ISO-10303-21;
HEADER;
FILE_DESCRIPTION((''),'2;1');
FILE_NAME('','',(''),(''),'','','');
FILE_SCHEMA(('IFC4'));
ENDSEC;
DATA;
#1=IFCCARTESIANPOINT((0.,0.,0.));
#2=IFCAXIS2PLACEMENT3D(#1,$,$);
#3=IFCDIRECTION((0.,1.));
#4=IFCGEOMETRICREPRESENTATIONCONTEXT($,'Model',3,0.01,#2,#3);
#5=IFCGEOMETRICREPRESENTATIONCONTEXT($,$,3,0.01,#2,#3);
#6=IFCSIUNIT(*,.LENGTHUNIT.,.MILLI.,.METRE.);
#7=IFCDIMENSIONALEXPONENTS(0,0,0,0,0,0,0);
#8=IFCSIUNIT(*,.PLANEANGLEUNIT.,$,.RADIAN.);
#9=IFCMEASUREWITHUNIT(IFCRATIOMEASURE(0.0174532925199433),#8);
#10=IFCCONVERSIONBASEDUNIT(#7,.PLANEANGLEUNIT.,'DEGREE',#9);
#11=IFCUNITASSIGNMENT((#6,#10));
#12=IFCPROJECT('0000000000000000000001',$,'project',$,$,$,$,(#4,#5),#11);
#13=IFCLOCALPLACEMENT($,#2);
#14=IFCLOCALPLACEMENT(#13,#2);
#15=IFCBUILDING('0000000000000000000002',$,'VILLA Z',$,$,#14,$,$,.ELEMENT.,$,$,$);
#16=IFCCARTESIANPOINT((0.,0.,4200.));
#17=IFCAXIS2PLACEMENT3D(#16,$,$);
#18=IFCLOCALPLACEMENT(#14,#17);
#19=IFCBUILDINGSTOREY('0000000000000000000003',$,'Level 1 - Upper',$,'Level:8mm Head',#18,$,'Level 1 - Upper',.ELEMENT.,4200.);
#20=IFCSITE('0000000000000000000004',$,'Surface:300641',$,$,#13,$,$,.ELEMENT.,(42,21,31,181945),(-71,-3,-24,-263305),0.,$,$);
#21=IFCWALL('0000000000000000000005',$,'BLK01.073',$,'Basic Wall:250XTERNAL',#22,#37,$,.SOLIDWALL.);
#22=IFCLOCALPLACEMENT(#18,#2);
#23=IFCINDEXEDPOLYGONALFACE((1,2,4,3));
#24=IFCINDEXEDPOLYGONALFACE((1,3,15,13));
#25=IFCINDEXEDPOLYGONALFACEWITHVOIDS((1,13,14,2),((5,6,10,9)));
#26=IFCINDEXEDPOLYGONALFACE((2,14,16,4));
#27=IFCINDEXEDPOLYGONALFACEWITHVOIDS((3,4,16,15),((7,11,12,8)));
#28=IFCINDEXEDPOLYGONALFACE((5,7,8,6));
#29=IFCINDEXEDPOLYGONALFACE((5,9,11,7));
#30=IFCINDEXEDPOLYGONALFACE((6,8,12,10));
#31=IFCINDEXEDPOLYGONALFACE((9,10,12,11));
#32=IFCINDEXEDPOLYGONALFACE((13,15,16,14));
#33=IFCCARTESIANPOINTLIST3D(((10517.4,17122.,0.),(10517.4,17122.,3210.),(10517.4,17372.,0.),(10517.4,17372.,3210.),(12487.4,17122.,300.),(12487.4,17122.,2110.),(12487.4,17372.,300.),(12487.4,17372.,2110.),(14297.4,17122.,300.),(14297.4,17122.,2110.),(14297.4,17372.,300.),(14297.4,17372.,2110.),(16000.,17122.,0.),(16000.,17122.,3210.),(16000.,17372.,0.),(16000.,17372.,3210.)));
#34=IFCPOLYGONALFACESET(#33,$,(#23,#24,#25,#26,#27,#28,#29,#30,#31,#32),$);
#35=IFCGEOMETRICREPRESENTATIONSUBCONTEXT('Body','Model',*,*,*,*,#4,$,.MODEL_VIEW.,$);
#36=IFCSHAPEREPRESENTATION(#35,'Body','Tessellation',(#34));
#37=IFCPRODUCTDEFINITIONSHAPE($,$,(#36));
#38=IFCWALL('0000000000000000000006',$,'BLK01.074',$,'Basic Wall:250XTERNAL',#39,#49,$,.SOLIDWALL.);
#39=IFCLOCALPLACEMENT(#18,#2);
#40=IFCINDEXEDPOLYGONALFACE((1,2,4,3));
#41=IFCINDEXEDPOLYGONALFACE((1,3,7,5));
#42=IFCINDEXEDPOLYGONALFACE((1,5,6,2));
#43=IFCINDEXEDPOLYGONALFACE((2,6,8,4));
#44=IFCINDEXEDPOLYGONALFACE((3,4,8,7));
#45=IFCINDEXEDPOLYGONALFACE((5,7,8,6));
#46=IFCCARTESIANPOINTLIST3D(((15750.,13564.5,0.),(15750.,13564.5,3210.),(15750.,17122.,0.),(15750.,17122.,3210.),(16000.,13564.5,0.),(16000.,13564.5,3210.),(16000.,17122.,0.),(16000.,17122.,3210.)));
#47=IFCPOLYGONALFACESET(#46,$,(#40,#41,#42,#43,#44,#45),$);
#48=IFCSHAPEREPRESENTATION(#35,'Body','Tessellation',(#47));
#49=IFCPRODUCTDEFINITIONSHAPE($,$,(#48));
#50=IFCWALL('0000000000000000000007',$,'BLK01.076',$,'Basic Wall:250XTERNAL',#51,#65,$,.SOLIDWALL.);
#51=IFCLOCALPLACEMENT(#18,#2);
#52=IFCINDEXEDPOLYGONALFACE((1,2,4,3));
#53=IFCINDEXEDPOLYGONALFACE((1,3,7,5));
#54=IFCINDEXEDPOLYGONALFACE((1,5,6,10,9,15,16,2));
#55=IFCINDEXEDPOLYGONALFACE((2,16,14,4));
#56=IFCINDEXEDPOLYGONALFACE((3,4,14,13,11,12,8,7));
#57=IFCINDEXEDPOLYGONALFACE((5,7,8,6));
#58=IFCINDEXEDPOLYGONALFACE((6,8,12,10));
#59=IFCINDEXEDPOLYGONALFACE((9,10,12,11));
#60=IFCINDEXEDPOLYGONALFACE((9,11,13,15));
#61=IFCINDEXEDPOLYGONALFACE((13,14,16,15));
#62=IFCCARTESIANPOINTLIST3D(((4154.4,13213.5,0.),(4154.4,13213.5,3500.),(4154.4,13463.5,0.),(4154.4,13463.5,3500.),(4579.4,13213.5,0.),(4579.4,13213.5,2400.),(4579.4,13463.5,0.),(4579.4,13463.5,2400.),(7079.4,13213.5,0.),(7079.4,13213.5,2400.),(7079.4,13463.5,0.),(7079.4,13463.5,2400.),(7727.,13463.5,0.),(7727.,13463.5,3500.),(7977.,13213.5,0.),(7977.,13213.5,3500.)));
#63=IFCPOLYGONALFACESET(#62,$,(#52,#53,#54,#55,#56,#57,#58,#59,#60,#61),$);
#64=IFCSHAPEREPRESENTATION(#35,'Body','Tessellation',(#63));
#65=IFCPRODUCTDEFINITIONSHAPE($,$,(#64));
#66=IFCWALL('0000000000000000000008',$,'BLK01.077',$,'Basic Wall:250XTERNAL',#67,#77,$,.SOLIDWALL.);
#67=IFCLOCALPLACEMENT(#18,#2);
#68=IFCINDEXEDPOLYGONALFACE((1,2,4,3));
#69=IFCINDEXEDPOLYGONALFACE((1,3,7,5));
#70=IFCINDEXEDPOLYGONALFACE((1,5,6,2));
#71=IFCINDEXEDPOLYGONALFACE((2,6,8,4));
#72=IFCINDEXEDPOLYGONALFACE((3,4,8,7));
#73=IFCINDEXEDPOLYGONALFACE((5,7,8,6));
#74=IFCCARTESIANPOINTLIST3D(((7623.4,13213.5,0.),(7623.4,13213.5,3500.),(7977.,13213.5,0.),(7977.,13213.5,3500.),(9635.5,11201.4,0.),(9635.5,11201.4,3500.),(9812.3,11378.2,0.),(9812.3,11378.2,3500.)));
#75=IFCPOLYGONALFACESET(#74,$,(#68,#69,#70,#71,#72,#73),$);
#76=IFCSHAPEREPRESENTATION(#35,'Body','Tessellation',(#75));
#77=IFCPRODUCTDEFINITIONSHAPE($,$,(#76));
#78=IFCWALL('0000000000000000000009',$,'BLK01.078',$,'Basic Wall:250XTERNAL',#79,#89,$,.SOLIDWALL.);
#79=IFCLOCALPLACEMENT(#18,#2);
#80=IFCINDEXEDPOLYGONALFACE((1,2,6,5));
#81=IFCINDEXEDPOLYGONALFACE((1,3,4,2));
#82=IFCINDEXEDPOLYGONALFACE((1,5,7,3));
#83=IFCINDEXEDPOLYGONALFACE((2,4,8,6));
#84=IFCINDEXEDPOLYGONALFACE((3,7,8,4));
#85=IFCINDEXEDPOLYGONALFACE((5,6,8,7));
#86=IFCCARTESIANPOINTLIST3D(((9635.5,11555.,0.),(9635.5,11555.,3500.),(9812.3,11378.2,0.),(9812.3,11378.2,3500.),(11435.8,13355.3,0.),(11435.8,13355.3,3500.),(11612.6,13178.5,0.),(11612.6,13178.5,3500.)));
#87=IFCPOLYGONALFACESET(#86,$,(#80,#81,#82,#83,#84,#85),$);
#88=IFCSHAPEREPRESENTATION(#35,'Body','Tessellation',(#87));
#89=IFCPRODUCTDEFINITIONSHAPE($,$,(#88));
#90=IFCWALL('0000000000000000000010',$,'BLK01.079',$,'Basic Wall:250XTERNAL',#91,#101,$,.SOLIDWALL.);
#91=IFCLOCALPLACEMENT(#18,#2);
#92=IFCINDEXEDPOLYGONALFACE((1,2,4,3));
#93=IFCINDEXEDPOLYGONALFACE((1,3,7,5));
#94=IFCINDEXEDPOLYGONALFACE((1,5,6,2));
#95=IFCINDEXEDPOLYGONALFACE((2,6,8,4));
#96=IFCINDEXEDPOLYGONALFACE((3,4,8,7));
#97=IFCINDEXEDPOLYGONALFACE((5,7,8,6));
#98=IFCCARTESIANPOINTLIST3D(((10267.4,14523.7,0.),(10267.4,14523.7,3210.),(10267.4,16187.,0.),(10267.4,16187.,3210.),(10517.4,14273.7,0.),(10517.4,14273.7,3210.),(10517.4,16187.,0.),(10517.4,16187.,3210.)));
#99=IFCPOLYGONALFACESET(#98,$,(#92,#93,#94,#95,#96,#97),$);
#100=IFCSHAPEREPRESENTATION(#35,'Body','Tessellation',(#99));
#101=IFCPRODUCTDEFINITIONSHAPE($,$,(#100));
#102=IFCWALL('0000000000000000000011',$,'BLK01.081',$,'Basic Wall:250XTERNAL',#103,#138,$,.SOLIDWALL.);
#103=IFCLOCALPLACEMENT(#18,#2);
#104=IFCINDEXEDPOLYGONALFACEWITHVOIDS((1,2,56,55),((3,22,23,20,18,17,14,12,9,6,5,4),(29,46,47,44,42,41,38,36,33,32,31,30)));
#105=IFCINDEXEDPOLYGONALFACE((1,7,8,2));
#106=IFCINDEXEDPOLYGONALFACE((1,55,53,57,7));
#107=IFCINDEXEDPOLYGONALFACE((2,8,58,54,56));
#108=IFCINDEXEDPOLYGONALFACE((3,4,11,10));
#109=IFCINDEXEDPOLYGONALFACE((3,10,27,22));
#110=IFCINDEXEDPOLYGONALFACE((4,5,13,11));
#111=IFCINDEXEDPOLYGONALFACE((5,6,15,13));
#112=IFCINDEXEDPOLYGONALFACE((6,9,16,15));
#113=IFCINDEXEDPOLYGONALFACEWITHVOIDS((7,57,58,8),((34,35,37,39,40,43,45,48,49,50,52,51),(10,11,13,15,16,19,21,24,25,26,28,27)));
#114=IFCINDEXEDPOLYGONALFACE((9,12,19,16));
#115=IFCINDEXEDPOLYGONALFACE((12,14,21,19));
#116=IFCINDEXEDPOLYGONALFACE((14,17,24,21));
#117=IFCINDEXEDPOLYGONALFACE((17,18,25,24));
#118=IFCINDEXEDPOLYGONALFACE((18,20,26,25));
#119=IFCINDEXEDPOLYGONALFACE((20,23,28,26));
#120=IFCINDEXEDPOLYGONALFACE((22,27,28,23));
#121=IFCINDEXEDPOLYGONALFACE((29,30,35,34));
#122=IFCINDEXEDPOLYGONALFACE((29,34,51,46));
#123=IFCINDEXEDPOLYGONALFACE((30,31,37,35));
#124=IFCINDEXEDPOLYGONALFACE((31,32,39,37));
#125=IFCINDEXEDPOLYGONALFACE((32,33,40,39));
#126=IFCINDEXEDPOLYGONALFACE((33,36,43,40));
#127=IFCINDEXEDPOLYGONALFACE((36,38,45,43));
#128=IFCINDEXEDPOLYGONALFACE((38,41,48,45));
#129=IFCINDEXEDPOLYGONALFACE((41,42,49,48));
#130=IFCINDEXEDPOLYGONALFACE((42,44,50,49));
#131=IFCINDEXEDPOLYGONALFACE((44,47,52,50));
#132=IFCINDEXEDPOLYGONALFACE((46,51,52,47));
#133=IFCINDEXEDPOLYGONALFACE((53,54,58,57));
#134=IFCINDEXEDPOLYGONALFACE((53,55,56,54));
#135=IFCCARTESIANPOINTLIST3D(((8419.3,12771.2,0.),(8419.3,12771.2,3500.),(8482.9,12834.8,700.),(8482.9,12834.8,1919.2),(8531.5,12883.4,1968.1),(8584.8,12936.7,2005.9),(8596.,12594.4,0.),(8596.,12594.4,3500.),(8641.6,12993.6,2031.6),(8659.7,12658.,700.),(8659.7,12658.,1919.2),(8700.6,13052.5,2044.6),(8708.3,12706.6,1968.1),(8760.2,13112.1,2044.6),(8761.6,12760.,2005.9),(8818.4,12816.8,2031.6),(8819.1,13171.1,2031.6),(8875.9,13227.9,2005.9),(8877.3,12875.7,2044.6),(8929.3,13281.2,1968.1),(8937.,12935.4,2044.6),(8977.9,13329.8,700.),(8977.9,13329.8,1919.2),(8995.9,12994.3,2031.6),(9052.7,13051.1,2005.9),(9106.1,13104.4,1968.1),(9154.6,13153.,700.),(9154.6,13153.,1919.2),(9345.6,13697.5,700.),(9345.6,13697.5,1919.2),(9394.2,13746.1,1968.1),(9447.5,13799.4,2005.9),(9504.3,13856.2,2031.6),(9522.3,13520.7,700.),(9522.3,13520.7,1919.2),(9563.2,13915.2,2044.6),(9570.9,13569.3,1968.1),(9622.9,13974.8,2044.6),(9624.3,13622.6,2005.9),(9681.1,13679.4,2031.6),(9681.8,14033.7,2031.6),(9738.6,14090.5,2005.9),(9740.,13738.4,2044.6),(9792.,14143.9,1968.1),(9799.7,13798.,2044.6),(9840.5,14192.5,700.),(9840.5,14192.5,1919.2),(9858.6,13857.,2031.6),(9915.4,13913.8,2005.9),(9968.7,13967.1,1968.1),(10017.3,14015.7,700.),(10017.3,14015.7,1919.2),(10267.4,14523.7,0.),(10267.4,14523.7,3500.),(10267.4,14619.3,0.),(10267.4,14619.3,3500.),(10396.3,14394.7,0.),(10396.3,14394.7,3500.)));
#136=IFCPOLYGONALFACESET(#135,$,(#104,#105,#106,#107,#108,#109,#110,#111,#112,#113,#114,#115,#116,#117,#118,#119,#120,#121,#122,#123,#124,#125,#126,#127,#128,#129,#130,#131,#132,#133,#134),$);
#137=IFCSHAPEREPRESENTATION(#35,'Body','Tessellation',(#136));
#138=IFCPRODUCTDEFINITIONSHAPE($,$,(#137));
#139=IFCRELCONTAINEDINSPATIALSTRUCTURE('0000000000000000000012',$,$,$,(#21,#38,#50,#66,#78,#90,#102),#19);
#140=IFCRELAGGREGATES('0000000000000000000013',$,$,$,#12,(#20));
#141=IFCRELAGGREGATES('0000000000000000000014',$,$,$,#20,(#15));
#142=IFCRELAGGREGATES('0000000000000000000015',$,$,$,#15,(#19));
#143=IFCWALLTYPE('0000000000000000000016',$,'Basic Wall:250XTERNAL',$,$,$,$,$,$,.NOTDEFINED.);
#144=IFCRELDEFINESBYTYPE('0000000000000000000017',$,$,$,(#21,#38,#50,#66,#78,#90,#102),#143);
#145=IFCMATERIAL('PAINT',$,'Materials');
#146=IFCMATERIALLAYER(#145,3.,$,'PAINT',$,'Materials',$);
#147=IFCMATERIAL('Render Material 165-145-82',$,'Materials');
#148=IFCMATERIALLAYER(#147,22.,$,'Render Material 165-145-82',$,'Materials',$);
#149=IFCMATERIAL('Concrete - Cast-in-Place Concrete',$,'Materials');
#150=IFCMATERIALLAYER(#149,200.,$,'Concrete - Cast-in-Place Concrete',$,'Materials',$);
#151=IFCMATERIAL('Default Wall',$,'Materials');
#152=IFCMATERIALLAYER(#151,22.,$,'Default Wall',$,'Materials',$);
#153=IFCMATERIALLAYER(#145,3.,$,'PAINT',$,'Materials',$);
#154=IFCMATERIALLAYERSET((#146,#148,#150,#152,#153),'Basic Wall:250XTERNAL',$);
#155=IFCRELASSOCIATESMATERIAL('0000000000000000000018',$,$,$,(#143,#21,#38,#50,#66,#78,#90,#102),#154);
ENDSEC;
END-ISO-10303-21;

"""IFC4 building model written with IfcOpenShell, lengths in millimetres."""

from ifc_helpers import new_model, entity, si_unit, converted_unit, direction, frame, frame_2d, origin, place, context, subcontext, project, spatial, polyline, circle_curve, parameter, trimmed, segment, composite_curve, rectangle, outline, extrude, clip, halfspace, bounded_halfspace, material, layer, layer_set, layer_usage, type_object, element, save


model = new_model("IFC4")

# Units and contexts
model_context = context("Model", 3, precision=0.01, world=origin(), true_north=direction((0.0, 1.0)))
context_of_model = context(None, 3, precision=0.01, world=origin(), true_north=direction((0.0, 1.0)))
body_context = subcontext(model_context, "Body", "Model", "MODEL_VIEW")
ifc_project = project(units=[si_unit("LENGTHUNIT", "METRE", prefix="MILLI"), converted_unit("PLANEANGLEUNIT", "DEGREE", entity("IfcRatioMeasure", 0.0174532925199433), si_unit("PLANEANGLEUNIT", "RADIAN"), dimensions=[0, 0, 0, 0, 0, 0, 0])], contexts=[model_context, context_of_model])

# Site, building, storey
site_placement = place(None, origin())
site = spatial("IfcSite", under=ifc_project, at=site_placement, Name="Surface:300641", CompositionType="ELEMENT", RefLatitude=(42, 21, 31, 181945), RefLongitude=(-71, -3, -24, -263305), RefElevation=0.0)
building_placement = place(site_placement, origin())
building = spatial("IfcBuilding", under=site, at=building_placement, Name="VILLA Z", CompositionType="ELEMENT")
storey_placement = place(building_placement, frame((0.0, 0.0, 4200.0)))
storey = spatial("IfcBuildingStorey", under=building, at=storey_placement, Name="Level 1 - Upper", ObjectType="Level:8mm Head", LongName="Level 1 - Upper", CompositionType="ELEMENT", Elevation=4200.0)

# Shared definitions
ifc_material_1 = material(Name="PAINT", Category="Materials")
ifc_layer_1 = layer(ifc_material_1, 3.0, Name="PAINT", Category="Materials")
ifc_material_2 = material(Name="Render Material 165-145-82", Category="Materials")
ifc_layer_2 = layer(ifc_material_2, 22.0, Name="Render Material 165-145-82", Category="Materials")
ifc_material_3 = material(Name="Concrete - Cast-in-Place Concrete", Category="Materials")
ifc_layer_3 = layer(ifc_material_3, 200.0, Name="Concrete - Cast-in-Place Concrete", Category="Materials")
ifc_material_4 = material(Name="Default Wall", Category="Materials")
ifc_layer_4 = layer(ifc_material_4, 22.0, Name="Default Wall", Category="Materials")
ifc_layer_5 = layer(ifc_material_1, 3.0, Name="PAINT", Category="Materials")
ifc_layer_set_1 = layer_set([ifc_layer_1, ifc_layer_2, ifc_layer_3, ifc_layer_4, ifc_layer_5], Name="Basic Wall:250XTERNAL")
wall_type_1 = type_object("IfcWallType", Name="Basic Wall:250XTERNAL", PredefinedType="NOTDEFINED", material=ifc_layer_set_1)

# Wall, opening
ifc_layer_usage_1 = layer_usage(ifc_layer_set_1, "AXIS2", "NEGATIVE", 125.0)
wall_1_placement = place(storey_placement, frame((10517.4, 17247.0, 0.0)))
wall_1 = element("IfcWall", 1, at=wall_1_placement, inside=storey, type_object=wall_type_1, material=ifc_layer_usage_1, Name="BLK01.073", ObjectType="Basic Wall:250XTERNAL", PredefinedType="SOLIDWALL", context=body_context, shape_type="Clipping", body=[
    clip(clip(extrude(rectangle(XDim=5482.6, YDim=250.0, at=frame_2d((2741.3, 0.0), x_axis=(-1.0, 0.0))), origin(), (0.0, 0.0, 1.0), 3210.0), bounded_halfspace(frame((0.0, -125.0, 3210.0), z_axis=(0.0, 0.0, -1.0), x_axis=(0.0, -1.0, 0.0)), True, frame((0.0, -125.0, 3210.0)), polyline([(0.0, 0.0), (5232.6, 0.0), (5482.6, 0.0), (5482.6, 250.0), (0.0, 250.0), (0.0, 0.0)]))), halfspace(frame((0.0, 0.0, -400.0)), True)),
])
opening_1_placement = place(wall_1_placement, frame((1970.0, -1649.0, 300.0)))
element("IfcOpeningElement", 2, at=opening_1_placement, cuts=wall_1, ObjectType="Opening", PredefinedType="OPENING", context=body_context, shape_type="SweptSolid", body=[
    extrude(rectangle(XDim=1810.0, YDim=1810.0, at=frame_2d((0.0, 0.0), x_axis=(0.0, 1.0))), frame((905.0, 0.0, 905.0), z_axis=(0.0, 1.0, 0.0), x_axis=(1.0, 0.0, 0.0)), (0.0, 0.0, 1.0), 3048.0),
])

# Wall
ifc_layer_usage_2 = layer_usage(ifc_layer_set_1, "AXIS2", "NEGATIVE", 125.0)
wall_2_placement = place(storey_placement, frame((15875.0, 17122.0, 0.0), z_axis=(0.0, 0.0, 1.0), x_axis=(0.0, -1.0, 0.0)))
element("IfcWall", 3, at=wall_2_placement, inside=storey, type_object=wall_type_1, material=ifc_layer_usage_2, Name="BLK01.074", ObjectType="Basic Wall:250XTERNAL", PredefinedType="SOLIDWALL", context=body_context, shape_type="Clipping", body=[
    clip(clip(extrude(rectangle(XDim=3557.5, YDim=250.0, at=frame_2d((1778.8, 0.0), x_axis=(-1.0, 0.0))), origin(), (0.0, 0.0, 1.0), 3210.0), bounded_halfspace(frame((0.0, 125.0, 3210.0), z_axis=(0.0, 0.0, -1.0), x_axis=(1.0, 0.0, 0.0)), True, frame((0.0, 125.0, 3210.0)), polyline([(0.0, 0.0), (0.0, -250.0), (3557.5, -250.0), (3557.5, 0.0), (0.0, 0.0)]))), halfspace(frame((0.0, 0.0, -400.0)), True)),
])

# Wall, opening
ifc_layer_usage_3 = layer_usage(ifc_layer_set_1, "AXIS2", "NEGATIVE", 125.0)
wall_3_placement = place(storey_placement, frame((4154.4, 13338.5, 0.0)))
wall_3 = element("IfcWall", 4, at=wall_3_placement, inside=storey, type_object=wall_type_1, material=ifc_layer_usage_3, Name="BLK01.076", ObjectType="Basic Wall:250XTERNAL", PredefinedType="SOLIDWALL", context=body_context, shape_type="Clipping", body=[
    clip(extrude(outline(polyline([(0.0, -125.0), (3469.0, -125.0), (3822.5, -125.0), (3572.5, 125.0), (0.0, 125.0), (0.0, -125.0)])), origin(), (0.0, 0.0, 1.0), 3500.0), halfspace(origin(), True)),
])
opening_2_placement = place(wall_3_placement, frame((2925.0, 125.0, 0.0)))
element("IfcOpeningElement", 5, at=opening_2_placement, cuts=wall_3, ObjectType="Opening", PredefinedType="OPENING", context=body_context, shape_type="SweptSolid", body=[
    extrude(rectangle(XDim=2400.0, YDim=2500.0, at=frame_2d((1200.0, 1250.0), x_axis=(-1.0, 0.0))), frame((0.0, 0.0, 0.0), z_axis=(0.0, -1.0, 0.0), x_axis=(0.0, 0.0, 1.0)), (0.0, 0.0, 1.0), 250.0),
])

# Walls
ifc_layer_usage_4 = layer_usage(ifc_layer_set_1, "AXIS2", "NEGATIVE", 125.0)
wall_4_placement = place(storey_placement, frame((7711.8, 13301.9, 0.0), z_axis=(0.0, 0.0, 1.0), x_axis=(0.707107, -0.707107, 0.0)))
element("IfcWall", 6, at=wall_4_placement, inside=storey, type_object=wall_type_1, material=ifc_layer_usage_4, Name="BLK01.077", ObjectType="Basic Wall:250XTERNAL", PredefinedType="SOLIDWALL", context=body_context, shape_type="Clipping", body=[
    clip(extrude(outline(polyline([(2845.5, -125.0), (2845.5, 0.0), (2845.5, 125.0), (2595.5, 125.0), (1125.5, 125.0), (875.5, 125.0), (250.0, 125.0), (0.0, -125.0), (2845.5, -125.0)])), origin(), (0.0, 0.0, 1.0), 3500.0), halfspace(origin(), True)),
])
ifc_layer_usage_5 = layer_usage(ifc_layer_set_1, "AXIS2", "NEGATIVE", 125.0)
wall_5_placement = place(storey_placement, frame((9723.9, 11466.6, 0.0), z_axis=(0.0, 0.0, 1.0), x_axis=(0.707107, 0.707107, 0.0)))
element("IfcWall", 7, at=wall_5_placement, inside=storey, type_object=wall_type_1, material=ifc_layer_usage_5, Name="BLK01.078", ObjectType="Basic Wall:250XTERNAL", PredefinedType="SOLIDWALL", context=body_context, shape_type="Clipping", body=[
    clip(extrude(rectangle(XDim=2546.0, YDim=250.0, at=frame_2d((1273.0, 0.0), x_axis=(-1.0, 0.0))), origin(), (0.0, 0.0, 1.0), 3500.0), halfspace(origin(), True)),
])
ifc_layer_usage_6 = layer_usage(ifc_layer_set_1, "AXIS2", "NEGATIVE", 125.0)
wall_6_placement = place(storey_placement, frame((10392.4, 16187.0, 0.0), z_axis=(0.0, 0.0, 1.0), x_axis=(0.0, -1.0, 0.0)))
element("IfcWall", 8, at=wall_6_placement, inside=storey, type_object=wall_type_1, material=ifc_layer_usage_6, Name="BLK01.079", ObjectType="Basic Wall:250XTERNAL", PredefinedType="SOLIDWALL", context=body_context, shape_type="Clipping", body=[
    clip(clip(extrude(outline(polyline([(1663.3, -125.0), (1792.3, 4.0), (1913.3, 125.0), (1735.1, 125.0), (0.0, 125.0), (0.0, -125.0), (1567.7, -125.0), (1663.3, -125.0)])), origin(), (0.0, 0.0, 1.0), 3210.0), bounded_halfspace(frame((0.0, -125.0, 3210.0), z_axis=(0.0, 0.0, -1.0), x_axis=(1.0, 0.0, 0.0)), True, frame((0.0, -125.0, 3210.0)), polyline([(0.0, 0.0), (1663.3, 0.0), (1913.3, 250.0), (0.0, 250.0), (0.0, 0.0)]))), halfspace(origin(), True)),
])

# Wall, openings
ifc_layer_usage_7 = layer_usage(ifc_layer_set_1, "AXIS2", "POSITIVE", -125.0)
wall_7_placement = place(storey_placement, frame((8507.6, 12682.8, 0.0), z_axis=(0.0, 0.0, 1.0), x_axis=(0.707107, 0.707107, 0.0)))
wall_7 = element("IfcWall", 9, at=wall_7_placement, inside=storey, type_object=wall_type_1, material=ifc_layer_usage_7, Name="BLK01.081", ObjectType="Basic Wall:250XTERNAL", PredefinedType="SOLIDWALL", context=body_context, shape_type="Clipping", body=[
    clip(extrude(outline(polyline([(2546.0, -125.0), (2546.0, 57.4), (2613.6, 125.0), (0.0, 125.0), (0.0, -125.0), (2546.0, -125.0)])), origin(), (0.0, 0.0, 1.0), 3500.0), halfspace(origin(), True)),
])
opening_3_placement = place(wall_7_placement, frame((790.0, 125.0, 700.0)))
element("IfcOpeningElement", 10, at=opening_3_placement, cuts=wall_7, ObjectType="Opening", PredefinedType="OPENING", context=body_context, shape_type="SweptSolid", body=[
    extrude(outline(composite_curve([segment(polyline([(0.0, 0.0), (1219.2, 0.0)]), True, "CONTINUOUS"), segment(trimmed(circle_curve(frame_2d((800.4, 350.0), x_axis=(0.0, 1.0)), 545.8), [parameter(230.112671)], [parameter(309.887329)], True, "PARAMETER"), True, "CONTINUOUS"), segment(polyline([(1219.2, 700.0), (0.0, 700.0)]), True, "CONTINUOUS"), segment(polyline([(0.0, 700.0), (0.0, 0.0)]), True, "CONTINUOUS")], self_intersect=False)), frame((0.0, 0.0, 0.0), z_axis=(0.0, -1.0, 0.0), x_axis=(0.0, 0.0, 1.0)), (0.0, 0.0, 1.0), 250.0),
])
opening_4_placement = place(wall_7_placement, frame((2010.0, 125.0, 700.0)))
element("IfcOpeningElement", 11, at=opening_4_placement, cuts=wall_7, ObjectType="Opening", PredefinedType="OPENING", context=body_context, shape_type="SweptSolid", body=[
    extrude(outline(composite_curve([segment(polyline([(0.0, 0.0), (1219.2, 0.0)]), True, "CONTINUOUS"), segment(trimmed(circle_curve(frame_2d((800.4, 350.0), x_axis=(0.0, 1.0)), 545.8), [parameter(230.112671)], [parameter(309.887329)], True, "PARAMETER"), True, "CONTINUOUS"), segment(polyline([(1219.2, 700.0), (0.0, 700.0)]), True, "CONTINUOUS"), segment(polyline([(0.0, 700.0), (0.0, 0.0)]), True, "CONTINUOUS")], self_intersect=False)), frame((0.0, 0.0, 0.0), z_axis=(0.0, -1.0, 0.0), x_axis=(0.0, 0.0, 1.0)), (0.0, 0.0, 1.0), 250.0),
])

save(model, "model.ifc")
